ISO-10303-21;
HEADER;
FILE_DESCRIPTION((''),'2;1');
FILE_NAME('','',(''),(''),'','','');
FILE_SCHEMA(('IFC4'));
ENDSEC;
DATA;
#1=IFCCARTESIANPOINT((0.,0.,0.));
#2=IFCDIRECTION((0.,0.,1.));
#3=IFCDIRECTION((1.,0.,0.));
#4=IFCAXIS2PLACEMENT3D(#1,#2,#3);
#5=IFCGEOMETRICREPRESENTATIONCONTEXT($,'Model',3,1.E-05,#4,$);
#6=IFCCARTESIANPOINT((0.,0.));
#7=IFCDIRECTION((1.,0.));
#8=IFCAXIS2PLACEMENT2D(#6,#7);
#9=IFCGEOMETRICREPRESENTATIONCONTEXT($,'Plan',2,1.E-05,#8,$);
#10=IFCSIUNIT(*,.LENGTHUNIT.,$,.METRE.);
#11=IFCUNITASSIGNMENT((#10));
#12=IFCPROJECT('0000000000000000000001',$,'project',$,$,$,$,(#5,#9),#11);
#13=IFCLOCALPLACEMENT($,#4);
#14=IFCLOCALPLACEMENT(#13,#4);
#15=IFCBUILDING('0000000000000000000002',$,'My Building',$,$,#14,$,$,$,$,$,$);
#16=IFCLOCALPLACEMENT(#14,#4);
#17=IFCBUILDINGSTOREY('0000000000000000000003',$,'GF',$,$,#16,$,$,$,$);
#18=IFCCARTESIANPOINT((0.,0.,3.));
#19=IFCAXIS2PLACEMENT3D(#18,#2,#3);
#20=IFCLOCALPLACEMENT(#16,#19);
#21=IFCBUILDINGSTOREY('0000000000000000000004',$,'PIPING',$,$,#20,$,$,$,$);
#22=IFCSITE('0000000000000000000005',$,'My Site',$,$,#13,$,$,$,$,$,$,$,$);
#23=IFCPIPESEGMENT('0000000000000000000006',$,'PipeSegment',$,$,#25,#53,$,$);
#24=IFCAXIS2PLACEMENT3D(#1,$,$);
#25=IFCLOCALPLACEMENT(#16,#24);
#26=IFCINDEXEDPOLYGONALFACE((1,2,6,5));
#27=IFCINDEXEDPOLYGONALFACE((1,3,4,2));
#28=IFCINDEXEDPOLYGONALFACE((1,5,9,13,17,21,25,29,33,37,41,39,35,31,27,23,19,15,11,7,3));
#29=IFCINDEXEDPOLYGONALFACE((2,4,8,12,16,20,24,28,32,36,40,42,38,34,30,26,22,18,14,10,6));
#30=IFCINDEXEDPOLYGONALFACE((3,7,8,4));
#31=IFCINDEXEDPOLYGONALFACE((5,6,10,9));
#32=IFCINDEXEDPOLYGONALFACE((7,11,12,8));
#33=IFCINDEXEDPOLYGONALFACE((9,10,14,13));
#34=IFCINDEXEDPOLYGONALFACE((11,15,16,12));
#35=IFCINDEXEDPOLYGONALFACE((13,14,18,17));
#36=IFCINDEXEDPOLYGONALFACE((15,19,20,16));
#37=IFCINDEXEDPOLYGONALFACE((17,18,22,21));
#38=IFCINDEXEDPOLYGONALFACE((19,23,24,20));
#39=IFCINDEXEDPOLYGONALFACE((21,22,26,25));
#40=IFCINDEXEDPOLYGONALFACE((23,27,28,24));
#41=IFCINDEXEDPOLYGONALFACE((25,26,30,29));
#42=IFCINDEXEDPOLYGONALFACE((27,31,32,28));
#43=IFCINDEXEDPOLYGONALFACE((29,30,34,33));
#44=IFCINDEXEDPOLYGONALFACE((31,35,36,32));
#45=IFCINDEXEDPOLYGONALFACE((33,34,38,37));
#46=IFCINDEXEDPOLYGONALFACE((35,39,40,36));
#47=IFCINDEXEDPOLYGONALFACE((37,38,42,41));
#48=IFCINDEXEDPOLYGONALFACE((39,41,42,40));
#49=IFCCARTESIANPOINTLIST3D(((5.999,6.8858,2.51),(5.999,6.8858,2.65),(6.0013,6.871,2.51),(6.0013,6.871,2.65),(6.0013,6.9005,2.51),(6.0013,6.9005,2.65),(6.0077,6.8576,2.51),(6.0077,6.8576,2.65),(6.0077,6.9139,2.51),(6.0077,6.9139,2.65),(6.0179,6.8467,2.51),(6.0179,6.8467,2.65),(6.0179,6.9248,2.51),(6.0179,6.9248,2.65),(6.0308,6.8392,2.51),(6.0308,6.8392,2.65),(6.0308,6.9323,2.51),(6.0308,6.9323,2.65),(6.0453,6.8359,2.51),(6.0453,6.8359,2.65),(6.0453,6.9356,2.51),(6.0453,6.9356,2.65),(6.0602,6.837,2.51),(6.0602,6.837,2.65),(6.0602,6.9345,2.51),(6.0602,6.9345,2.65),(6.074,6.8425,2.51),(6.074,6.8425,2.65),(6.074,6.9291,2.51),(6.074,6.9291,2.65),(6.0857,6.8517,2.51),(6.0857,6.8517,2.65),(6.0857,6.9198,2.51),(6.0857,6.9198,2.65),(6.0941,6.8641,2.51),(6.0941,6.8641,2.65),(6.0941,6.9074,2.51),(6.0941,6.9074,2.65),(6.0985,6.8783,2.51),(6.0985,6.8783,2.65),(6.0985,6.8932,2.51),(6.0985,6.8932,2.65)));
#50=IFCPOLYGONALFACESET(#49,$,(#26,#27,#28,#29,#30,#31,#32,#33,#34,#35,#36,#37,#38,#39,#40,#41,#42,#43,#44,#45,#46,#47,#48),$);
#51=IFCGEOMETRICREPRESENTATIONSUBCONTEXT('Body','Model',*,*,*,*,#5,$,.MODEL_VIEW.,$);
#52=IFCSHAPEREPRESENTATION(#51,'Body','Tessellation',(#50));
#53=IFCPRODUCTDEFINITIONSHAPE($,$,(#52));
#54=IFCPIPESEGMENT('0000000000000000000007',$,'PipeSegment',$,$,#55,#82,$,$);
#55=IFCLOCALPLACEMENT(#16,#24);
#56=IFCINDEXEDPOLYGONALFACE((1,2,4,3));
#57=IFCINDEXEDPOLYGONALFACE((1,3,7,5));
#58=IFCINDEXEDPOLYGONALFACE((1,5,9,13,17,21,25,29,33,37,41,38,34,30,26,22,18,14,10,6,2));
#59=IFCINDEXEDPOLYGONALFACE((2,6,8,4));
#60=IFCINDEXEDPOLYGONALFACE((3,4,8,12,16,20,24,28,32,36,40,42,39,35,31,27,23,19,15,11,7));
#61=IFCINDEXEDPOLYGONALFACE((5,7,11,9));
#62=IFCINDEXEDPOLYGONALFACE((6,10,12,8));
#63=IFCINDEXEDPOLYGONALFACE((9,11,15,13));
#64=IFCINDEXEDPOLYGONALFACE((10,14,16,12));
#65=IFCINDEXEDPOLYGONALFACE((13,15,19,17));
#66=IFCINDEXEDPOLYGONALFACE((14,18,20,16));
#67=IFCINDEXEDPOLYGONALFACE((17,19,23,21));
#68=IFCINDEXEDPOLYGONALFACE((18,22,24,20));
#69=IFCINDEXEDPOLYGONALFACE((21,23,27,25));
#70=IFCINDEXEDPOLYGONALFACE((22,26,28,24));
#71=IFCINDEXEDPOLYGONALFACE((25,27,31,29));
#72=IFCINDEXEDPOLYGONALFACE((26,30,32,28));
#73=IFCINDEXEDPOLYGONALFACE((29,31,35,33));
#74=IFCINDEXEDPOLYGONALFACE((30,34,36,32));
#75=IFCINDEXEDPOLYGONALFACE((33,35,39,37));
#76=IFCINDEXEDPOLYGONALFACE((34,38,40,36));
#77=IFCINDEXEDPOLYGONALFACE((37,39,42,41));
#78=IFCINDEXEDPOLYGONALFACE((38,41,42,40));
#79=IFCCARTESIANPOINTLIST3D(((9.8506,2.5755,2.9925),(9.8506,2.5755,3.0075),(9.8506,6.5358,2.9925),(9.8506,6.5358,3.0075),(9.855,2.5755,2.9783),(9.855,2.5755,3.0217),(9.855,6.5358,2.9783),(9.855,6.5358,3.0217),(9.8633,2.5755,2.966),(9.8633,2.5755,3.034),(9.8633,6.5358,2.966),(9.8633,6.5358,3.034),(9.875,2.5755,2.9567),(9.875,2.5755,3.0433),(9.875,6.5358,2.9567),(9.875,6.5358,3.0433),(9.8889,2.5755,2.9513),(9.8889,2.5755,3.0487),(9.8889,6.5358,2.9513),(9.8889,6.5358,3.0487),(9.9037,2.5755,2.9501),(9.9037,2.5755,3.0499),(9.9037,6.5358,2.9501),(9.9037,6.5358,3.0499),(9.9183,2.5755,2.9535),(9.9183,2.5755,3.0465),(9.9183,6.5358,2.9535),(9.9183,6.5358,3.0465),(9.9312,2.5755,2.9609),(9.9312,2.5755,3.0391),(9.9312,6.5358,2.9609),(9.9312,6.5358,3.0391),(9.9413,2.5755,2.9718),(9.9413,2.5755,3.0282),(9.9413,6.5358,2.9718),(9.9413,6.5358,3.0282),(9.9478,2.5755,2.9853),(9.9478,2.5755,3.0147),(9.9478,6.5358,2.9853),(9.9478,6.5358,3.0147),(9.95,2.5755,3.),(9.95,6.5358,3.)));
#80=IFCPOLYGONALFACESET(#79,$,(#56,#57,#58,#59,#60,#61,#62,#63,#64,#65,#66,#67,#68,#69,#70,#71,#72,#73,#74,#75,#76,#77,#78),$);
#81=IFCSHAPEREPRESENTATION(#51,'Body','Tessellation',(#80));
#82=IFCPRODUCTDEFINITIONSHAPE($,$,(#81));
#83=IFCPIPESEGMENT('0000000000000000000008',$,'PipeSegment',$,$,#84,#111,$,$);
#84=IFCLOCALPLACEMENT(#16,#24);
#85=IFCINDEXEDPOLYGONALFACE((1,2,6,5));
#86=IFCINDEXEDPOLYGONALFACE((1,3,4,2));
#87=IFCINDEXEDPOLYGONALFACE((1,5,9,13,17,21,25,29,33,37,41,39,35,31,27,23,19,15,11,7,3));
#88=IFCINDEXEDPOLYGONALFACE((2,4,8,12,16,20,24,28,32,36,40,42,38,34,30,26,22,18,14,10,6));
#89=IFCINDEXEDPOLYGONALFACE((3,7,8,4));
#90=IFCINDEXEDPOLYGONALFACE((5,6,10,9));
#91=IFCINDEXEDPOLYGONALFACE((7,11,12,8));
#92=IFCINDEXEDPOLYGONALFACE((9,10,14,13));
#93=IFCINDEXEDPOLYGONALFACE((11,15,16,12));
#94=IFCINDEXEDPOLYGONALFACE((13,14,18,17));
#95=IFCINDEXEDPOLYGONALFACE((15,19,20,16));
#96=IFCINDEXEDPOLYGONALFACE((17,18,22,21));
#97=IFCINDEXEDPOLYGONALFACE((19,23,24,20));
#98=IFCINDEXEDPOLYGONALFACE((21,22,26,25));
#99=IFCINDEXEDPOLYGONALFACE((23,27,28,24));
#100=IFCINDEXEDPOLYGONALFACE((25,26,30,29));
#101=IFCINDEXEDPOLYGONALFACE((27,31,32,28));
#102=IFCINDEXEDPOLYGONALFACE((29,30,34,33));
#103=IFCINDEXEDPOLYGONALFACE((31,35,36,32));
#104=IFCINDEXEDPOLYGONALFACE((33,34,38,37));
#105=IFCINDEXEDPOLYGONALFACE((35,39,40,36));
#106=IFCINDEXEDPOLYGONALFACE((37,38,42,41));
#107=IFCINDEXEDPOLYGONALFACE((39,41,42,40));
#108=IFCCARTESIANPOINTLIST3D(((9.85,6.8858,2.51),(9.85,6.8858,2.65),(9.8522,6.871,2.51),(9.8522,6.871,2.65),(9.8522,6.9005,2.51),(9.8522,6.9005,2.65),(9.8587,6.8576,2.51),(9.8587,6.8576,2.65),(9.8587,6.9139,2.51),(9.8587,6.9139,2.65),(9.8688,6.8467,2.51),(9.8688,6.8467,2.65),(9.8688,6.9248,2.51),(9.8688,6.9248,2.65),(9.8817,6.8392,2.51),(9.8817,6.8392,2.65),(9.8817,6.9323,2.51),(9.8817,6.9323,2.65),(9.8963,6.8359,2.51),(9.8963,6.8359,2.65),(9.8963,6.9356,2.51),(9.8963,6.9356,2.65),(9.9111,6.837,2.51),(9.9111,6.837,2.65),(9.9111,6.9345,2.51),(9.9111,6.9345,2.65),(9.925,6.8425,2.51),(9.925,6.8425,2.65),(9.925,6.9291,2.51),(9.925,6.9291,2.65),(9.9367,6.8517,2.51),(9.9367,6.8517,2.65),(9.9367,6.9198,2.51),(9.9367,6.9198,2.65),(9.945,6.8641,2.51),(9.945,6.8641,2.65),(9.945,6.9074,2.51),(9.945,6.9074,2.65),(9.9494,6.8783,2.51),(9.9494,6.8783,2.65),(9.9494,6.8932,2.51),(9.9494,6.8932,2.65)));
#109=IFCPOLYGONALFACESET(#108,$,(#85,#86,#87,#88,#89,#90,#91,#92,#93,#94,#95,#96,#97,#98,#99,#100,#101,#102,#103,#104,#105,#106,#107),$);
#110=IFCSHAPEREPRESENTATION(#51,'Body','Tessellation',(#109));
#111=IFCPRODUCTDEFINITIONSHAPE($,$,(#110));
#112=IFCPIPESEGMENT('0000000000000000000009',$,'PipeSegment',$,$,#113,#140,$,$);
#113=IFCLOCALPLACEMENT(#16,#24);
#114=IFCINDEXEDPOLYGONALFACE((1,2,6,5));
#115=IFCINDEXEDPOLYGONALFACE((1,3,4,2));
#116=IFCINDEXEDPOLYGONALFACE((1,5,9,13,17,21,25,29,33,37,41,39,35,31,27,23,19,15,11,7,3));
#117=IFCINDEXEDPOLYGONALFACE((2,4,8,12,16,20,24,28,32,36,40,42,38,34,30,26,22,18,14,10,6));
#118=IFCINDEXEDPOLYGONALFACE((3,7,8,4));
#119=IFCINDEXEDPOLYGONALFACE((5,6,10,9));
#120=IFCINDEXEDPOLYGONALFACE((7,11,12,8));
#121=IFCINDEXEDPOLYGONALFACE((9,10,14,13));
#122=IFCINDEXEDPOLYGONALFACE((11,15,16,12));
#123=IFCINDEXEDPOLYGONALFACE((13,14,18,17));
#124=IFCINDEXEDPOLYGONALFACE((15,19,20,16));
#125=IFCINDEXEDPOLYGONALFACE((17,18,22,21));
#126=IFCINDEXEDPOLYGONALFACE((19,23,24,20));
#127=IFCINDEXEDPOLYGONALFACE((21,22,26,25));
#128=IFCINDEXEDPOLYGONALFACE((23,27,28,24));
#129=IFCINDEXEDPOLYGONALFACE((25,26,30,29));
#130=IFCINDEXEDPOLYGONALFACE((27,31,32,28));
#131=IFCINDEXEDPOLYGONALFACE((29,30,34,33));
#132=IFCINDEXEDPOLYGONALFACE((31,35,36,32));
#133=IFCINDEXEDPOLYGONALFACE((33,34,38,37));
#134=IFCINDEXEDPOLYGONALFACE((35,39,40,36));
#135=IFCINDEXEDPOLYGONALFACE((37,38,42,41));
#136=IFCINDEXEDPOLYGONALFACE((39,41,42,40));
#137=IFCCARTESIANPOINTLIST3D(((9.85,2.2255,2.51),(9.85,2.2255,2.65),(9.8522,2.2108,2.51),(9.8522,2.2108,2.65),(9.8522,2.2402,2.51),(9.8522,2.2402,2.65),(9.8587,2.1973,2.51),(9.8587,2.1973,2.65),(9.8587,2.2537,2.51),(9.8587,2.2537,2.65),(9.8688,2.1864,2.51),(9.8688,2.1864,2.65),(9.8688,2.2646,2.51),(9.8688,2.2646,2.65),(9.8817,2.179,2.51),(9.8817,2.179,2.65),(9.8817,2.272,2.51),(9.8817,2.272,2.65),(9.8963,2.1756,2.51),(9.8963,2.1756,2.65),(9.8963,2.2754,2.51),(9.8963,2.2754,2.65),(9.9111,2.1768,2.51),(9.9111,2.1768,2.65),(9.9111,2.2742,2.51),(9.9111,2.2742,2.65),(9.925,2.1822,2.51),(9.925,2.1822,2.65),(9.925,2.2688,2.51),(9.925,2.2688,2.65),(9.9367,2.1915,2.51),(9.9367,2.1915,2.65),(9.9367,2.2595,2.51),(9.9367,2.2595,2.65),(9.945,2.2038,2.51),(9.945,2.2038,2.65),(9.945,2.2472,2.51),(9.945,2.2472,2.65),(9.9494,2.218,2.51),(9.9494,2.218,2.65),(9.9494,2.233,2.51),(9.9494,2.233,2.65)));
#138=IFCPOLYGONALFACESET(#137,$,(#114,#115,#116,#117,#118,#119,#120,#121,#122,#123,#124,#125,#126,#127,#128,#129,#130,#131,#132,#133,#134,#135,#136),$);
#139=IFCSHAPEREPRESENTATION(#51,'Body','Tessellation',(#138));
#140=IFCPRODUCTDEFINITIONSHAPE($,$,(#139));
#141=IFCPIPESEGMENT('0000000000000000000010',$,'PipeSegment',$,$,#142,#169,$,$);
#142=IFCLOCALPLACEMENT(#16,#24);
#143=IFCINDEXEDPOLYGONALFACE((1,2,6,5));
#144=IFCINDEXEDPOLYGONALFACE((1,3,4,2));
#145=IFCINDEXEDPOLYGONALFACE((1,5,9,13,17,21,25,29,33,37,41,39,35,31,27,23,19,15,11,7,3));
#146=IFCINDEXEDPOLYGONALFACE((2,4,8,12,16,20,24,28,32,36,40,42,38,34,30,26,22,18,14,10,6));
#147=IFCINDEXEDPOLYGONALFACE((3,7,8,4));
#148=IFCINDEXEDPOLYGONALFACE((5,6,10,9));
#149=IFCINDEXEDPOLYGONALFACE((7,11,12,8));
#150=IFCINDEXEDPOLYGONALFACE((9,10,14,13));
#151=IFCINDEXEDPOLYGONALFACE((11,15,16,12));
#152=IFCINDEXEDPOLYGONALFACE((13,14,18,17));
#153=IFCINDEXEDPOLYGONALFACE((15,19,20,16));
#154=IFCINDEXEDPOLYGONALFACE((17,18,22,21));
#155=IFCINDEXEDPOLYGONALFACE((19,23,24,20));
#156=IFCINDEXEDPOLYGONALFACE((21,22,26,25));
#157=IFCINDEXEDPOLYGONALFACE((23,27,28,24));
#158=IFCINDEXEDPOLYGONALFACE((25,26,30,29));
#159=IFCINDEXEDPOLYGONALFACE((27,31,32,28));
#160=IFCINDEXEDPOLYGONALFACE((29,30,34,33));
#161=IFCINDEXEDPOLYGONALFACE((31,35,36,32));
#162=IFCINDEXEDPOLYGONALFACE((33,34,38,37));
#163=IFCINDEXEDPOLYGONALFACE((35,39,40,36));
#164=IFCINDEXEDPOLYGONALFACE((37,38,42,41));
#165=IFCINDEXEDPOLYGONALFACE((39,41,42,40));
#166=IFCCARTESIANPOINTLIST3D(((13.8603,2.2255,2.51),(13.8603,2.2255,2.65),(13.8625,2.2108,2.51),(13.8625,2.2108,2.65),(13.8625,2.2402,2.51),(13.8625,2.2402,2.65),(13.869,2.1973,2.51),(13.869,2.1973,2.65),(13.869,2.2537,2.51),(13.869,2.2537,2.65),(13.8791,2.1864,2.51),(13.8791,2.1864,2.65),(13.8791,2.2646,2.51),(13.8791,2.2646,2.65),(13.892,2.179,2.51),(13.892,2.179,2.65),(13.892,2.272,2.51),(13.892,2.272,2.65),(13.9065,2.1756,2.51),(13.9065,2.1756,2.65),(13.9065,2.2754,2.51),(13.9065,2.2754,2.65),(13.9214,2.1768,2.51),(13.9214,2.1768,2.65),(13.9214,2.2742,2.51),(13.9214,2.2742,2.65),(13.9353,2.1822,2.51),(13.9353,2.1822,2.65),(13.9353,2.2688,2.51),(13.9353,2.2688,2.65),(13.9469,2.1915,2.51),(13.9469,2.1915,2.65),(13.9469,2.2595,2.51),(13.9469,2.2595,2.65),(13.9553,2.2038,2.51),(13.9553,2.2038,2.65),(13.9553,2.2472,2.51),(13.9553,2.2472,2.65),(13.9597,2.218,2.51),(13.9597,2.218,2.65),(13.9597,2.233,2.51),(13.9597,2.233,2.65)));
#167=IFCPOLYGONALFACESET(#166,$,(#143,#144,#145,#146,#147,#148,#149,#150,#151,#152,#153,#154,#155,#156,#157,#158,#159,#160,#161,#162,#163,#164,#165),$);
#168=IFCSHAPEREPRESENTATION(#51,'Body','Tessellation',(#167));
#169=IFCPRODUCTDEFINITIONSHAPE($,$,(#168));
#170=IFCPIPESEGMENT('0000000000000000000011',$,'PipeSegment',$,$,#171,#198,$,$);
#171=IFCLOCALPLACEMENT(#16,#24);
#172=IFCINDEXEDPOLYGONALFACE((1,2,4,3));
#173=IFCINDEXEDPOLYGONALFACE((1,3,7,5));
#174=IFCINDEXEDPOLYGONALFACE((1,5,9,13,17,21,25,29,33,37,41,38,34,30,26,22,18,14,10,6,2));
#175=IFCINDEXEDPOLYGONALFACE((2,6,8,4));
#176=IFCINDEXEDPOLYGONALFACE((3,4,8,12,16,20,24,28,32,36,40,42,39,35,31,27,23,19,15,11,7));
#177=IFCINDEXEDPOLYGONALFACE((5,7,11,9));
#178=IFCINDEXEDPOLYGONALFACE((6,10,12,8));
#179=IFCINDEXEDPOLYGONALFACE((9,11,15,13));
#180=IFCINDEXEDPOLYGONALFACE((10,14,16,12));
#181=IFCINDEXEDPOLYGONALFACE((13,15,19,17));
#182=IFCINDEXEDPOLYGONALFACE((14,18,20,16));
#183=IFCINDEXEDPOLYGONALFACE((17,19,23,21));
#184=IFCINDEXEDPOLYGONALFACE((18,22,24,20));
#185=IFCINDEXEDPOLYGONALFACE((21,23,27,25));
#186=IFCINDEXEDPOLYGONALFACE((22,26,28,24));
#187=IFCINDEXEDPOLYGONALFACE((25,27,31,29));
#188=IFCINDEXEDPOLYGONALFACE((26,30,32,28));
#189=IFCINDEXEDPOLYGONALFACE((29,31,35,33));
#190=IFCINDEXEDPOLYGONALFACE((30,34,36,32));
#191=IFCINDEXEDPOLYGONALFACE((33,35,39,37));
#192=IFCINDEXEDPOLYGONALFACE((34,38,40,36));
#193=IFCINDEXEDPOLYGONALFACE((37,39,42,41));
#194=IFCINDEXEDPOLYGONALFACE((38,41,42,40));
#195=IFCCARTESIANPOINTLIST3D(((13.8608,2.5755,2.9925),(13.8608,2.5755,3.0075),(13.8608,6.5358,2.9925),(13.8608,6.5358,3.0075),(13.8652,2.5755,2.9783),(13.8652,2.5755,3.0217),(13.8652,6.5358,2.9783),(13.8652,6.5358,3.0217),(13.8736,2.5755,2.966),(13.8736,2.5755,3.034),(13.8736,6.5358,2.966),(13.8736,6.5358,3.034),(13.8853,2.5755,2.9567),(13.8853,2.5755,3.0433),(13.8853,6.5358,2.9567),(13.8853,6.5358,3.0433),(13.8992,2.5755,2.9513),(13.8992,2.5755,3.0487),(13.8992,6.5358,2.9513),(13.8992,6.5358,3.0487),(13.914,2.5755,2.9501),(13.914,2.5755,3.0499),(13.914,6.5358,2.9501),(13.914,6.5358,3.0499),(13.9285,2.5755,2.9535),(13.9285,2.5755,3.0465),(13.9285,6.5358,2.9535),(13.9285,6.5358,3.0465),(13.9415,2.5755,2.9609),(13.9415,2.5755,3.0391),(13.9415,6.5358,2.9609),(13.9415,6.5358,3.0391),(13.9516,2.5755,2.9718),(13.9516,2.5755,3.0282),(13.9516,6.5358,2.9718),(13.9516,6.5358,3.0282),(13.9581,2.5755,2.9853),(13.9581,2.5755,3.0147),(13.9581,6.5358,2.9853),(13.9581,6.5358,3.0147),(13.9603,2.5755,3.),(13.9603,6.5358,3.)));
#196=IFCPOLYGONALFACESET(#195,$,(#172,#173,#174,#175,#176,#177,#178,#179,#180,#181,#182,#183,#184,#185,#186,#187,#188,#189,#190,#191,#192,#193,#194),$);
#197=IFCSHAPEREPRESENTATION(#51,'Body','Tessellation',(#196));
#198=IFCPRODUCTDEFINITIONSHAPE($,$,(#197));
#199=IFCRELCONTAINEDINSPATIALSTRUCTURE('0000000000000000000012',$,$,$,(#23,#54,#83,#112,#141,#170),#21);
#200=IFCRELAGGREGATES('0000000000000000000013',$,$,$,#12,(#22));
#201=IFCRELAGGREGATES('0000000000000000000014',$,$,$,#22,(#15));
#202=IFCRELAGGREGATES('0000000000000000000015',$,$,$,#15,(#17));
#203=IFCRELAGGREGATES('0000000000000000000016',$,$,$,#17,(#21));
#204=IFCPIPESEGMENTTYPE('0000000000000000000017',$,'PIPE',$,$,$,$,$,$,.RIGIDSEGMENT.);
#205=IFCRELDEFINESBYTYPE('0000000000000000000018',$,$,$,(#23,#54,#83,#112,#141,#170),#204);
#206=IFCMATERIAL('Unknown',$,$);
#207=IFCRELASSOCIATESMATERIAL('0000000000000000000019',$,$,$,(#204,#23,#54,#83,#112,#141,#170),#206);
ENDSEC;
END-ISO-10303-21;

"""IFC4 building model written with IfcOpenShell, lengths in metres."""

from ifc_helpers import new_model, si_unit, frame, origin_with_axes, origin_2d_with_axis, place, context, subcontext, project, spatial, circle, extrude, material, material_profile, profile_set, profile_usage, type_object, element, save


model = new_model("IFC4")

# Units and contexts
model_context = context("Model", 3, precision=1e-05, world=origin_with_axes())
plan_context = context("Plan", 2, precision=1e-05, world=origin_2d_with_axis())
body_context = subcontext(model_context, "Body", "Model", "MODEL_VIEW")
ifc_project = project(units=[si_unit("LENGTHUNIT", "METRE")], contexts=[model_context, plan_context])

# Site, building, storeys
site_placement = place(None, origin_with_axes())
site = spatial("IfcSite", under=ifc_project, at=site_placement, Name="My Site")
building_placement = place(site_placement, origin_with_axes())
building = spatial("IfcBuilding", under=site, at=building_placement, Name="My Building")
storey_1_placement = place(building_placement, origin_with_axes())
storey_1 = spatial("IfcBuildingStorey", under=building, at=storey_1_placement, Name="GF")
storey_2_placement = place(storey_1_placement, frame((0.0, 0.0, 3.0), z_axis=(0.0, 0.0, 1.0), x_axis=(1.0, 0.0, 0.0)))
storey_2 = spatial("IfcBuildingStorey", under=storey_1, at=storey_2_placement, Name="PIPING")

# Pipe segments
ifc_material = material(Name="Unknown")
ifc_material_profile = material_profile(ifc_material, circle(Radius=0.05))
ifc_profile_set = profile_set([ifc_material_profile])
pipe_segment_type = type_object("IfcPipeSegmentType", Name="PIPE", PredefinedType="RIGIDSEGMENT", material=ifc_profile_set)
ifc_profile_usage_1 = profile_usage(ifc_profile_set, cardinal=5)
pipe_segment_1_placement = place(storey_2_placement, frame((6.049, 6.8858, -0.35), z_axis=(0.0, 0.0, -1.0), x_axis=(-1.0, 0.0, 0.0)))
element("IfcPipeSegment", 1, at=pipe_segment_1_placement, inside=storey_2, type_object=pipe_segment_type, material=ifc_profile_usage_1, Name="PipeSegment", context=body_context, shape_type="SweptSolid", body=[
    extrude(circle(Radius=0.05), origin_with_axes(), (0.0, 0.0, 1.0), 0.14),
])
ifc_profile_usage_2 = profile_usage(ifc_profile_set, cardinal=5)
pipe_segment_2_placement = place(storey_2_placement, frame((9.9, 6.5358, 0.0), z_axis=(0.0, -1.0, 0.0), x_axis=(1.0, 0.0, 0.0)))
element("IfcPipeSegment", 2, at=pipe_segment_2_placement, inside=storey_2, type_object=pipe_segment_type, material=ifc_profile_usage_2, Name="PipeSegment", context=body_context, shape_type="SweptSolid", body=[
    extrude(circle(Radius=0.05), origin_with_axes(), (0.0, 0.0, 1.0), 3.9603),
])
ifc_profile_usage_3 = profile_usage(ifc_profile_set, cardinal=5)
pipe_segment_3_placement = place(storey_2_placement, frame((9.9, 6.8858, -0.35), z_axis=(0.0, 0.0, -1.0), x_axis=(-1.0, 0.0, 0.0)))
element("IfcPipeSegment", 3, at=pipe_segment_3_placement, inside=storey_2, type_object=pipe_segment_type, material=ifc_profile_usage_3, Name="PipeSegment", context=body_context, shape_type="SweptSolid", body=[
    extrude(circle(Radius=0.05), origin_with_axes(), (0.0, 0.0, 1.0), 0.14),
])
ifc_profile_usage_4 = profile_usage(ifc_profile_set, cardinal=5)
pipe_segment_4_placement = place(storey_2_placement, frame((9.9, 2.2255, -0.35), z_axis=(0.0, 0.0, -1.0), x_axis=(-1.0, 0.0, 0.0)))
element("IfcPipeSegment", 4, at=pipe_segment_4_placement, inside=storey_2, type_object=pipe_segment_type, material=ifc_profile_usage_4, Name="PipeSegment", context=body_context, shape_type="SweptSolid", body=[
    extrude(circle(Radius=0.05), origin_with_axes(), (0.0, 0.0, 1.0), 0.14),
])
ifc_profile_usage_5 = profile_usage(ifc_profile_set, cardinal=5)
pipe_segment_5_placement = place(storey_2_placement, frame((13.9103, 2.2255, -0.35), z_axis=(0.0, 0.0, -1.0), x_axis=(-1.0, 0.0, 0.0)))
element("IfcPipeSegment", 5, at=pipe_segment_5_placement, inside=storey_2, type_object=pipe_segment_type, material=ifc_profile_usage_5, Name="PipeSegment", context=body_context, shape_type="SweptSolid", body=[
    extrude(circle(Radius=0.05), origin_with_axes(), (0.0, 0.0, 1.0), 0.14),
])
ifc_profile_usage_6 = profile_usage(ifc_profile_set, cardinal=5)
pipe_segment_6_placement = place(storey_2_placement, frame((13.9103, 6.5358, 0.0), z_axis=(0.0, -1.0, 0.0), x_axis=(1.0, 0.0, 0.0)))
element("IfcPipeSegment", 6, at=pipe_segment_6_placement, inside=storey_2, type_object=pipe_segment_type, material=ifc_profile_usage_6, Name="PipeSegment", context=body_context, shape_type="SweptSolid", body=[
    extrude(circle(Radius=0.05), origin_with_axes(), (0.0, 0.0, 1.0), 3.9603),
])

save(model, "model.ifc")
